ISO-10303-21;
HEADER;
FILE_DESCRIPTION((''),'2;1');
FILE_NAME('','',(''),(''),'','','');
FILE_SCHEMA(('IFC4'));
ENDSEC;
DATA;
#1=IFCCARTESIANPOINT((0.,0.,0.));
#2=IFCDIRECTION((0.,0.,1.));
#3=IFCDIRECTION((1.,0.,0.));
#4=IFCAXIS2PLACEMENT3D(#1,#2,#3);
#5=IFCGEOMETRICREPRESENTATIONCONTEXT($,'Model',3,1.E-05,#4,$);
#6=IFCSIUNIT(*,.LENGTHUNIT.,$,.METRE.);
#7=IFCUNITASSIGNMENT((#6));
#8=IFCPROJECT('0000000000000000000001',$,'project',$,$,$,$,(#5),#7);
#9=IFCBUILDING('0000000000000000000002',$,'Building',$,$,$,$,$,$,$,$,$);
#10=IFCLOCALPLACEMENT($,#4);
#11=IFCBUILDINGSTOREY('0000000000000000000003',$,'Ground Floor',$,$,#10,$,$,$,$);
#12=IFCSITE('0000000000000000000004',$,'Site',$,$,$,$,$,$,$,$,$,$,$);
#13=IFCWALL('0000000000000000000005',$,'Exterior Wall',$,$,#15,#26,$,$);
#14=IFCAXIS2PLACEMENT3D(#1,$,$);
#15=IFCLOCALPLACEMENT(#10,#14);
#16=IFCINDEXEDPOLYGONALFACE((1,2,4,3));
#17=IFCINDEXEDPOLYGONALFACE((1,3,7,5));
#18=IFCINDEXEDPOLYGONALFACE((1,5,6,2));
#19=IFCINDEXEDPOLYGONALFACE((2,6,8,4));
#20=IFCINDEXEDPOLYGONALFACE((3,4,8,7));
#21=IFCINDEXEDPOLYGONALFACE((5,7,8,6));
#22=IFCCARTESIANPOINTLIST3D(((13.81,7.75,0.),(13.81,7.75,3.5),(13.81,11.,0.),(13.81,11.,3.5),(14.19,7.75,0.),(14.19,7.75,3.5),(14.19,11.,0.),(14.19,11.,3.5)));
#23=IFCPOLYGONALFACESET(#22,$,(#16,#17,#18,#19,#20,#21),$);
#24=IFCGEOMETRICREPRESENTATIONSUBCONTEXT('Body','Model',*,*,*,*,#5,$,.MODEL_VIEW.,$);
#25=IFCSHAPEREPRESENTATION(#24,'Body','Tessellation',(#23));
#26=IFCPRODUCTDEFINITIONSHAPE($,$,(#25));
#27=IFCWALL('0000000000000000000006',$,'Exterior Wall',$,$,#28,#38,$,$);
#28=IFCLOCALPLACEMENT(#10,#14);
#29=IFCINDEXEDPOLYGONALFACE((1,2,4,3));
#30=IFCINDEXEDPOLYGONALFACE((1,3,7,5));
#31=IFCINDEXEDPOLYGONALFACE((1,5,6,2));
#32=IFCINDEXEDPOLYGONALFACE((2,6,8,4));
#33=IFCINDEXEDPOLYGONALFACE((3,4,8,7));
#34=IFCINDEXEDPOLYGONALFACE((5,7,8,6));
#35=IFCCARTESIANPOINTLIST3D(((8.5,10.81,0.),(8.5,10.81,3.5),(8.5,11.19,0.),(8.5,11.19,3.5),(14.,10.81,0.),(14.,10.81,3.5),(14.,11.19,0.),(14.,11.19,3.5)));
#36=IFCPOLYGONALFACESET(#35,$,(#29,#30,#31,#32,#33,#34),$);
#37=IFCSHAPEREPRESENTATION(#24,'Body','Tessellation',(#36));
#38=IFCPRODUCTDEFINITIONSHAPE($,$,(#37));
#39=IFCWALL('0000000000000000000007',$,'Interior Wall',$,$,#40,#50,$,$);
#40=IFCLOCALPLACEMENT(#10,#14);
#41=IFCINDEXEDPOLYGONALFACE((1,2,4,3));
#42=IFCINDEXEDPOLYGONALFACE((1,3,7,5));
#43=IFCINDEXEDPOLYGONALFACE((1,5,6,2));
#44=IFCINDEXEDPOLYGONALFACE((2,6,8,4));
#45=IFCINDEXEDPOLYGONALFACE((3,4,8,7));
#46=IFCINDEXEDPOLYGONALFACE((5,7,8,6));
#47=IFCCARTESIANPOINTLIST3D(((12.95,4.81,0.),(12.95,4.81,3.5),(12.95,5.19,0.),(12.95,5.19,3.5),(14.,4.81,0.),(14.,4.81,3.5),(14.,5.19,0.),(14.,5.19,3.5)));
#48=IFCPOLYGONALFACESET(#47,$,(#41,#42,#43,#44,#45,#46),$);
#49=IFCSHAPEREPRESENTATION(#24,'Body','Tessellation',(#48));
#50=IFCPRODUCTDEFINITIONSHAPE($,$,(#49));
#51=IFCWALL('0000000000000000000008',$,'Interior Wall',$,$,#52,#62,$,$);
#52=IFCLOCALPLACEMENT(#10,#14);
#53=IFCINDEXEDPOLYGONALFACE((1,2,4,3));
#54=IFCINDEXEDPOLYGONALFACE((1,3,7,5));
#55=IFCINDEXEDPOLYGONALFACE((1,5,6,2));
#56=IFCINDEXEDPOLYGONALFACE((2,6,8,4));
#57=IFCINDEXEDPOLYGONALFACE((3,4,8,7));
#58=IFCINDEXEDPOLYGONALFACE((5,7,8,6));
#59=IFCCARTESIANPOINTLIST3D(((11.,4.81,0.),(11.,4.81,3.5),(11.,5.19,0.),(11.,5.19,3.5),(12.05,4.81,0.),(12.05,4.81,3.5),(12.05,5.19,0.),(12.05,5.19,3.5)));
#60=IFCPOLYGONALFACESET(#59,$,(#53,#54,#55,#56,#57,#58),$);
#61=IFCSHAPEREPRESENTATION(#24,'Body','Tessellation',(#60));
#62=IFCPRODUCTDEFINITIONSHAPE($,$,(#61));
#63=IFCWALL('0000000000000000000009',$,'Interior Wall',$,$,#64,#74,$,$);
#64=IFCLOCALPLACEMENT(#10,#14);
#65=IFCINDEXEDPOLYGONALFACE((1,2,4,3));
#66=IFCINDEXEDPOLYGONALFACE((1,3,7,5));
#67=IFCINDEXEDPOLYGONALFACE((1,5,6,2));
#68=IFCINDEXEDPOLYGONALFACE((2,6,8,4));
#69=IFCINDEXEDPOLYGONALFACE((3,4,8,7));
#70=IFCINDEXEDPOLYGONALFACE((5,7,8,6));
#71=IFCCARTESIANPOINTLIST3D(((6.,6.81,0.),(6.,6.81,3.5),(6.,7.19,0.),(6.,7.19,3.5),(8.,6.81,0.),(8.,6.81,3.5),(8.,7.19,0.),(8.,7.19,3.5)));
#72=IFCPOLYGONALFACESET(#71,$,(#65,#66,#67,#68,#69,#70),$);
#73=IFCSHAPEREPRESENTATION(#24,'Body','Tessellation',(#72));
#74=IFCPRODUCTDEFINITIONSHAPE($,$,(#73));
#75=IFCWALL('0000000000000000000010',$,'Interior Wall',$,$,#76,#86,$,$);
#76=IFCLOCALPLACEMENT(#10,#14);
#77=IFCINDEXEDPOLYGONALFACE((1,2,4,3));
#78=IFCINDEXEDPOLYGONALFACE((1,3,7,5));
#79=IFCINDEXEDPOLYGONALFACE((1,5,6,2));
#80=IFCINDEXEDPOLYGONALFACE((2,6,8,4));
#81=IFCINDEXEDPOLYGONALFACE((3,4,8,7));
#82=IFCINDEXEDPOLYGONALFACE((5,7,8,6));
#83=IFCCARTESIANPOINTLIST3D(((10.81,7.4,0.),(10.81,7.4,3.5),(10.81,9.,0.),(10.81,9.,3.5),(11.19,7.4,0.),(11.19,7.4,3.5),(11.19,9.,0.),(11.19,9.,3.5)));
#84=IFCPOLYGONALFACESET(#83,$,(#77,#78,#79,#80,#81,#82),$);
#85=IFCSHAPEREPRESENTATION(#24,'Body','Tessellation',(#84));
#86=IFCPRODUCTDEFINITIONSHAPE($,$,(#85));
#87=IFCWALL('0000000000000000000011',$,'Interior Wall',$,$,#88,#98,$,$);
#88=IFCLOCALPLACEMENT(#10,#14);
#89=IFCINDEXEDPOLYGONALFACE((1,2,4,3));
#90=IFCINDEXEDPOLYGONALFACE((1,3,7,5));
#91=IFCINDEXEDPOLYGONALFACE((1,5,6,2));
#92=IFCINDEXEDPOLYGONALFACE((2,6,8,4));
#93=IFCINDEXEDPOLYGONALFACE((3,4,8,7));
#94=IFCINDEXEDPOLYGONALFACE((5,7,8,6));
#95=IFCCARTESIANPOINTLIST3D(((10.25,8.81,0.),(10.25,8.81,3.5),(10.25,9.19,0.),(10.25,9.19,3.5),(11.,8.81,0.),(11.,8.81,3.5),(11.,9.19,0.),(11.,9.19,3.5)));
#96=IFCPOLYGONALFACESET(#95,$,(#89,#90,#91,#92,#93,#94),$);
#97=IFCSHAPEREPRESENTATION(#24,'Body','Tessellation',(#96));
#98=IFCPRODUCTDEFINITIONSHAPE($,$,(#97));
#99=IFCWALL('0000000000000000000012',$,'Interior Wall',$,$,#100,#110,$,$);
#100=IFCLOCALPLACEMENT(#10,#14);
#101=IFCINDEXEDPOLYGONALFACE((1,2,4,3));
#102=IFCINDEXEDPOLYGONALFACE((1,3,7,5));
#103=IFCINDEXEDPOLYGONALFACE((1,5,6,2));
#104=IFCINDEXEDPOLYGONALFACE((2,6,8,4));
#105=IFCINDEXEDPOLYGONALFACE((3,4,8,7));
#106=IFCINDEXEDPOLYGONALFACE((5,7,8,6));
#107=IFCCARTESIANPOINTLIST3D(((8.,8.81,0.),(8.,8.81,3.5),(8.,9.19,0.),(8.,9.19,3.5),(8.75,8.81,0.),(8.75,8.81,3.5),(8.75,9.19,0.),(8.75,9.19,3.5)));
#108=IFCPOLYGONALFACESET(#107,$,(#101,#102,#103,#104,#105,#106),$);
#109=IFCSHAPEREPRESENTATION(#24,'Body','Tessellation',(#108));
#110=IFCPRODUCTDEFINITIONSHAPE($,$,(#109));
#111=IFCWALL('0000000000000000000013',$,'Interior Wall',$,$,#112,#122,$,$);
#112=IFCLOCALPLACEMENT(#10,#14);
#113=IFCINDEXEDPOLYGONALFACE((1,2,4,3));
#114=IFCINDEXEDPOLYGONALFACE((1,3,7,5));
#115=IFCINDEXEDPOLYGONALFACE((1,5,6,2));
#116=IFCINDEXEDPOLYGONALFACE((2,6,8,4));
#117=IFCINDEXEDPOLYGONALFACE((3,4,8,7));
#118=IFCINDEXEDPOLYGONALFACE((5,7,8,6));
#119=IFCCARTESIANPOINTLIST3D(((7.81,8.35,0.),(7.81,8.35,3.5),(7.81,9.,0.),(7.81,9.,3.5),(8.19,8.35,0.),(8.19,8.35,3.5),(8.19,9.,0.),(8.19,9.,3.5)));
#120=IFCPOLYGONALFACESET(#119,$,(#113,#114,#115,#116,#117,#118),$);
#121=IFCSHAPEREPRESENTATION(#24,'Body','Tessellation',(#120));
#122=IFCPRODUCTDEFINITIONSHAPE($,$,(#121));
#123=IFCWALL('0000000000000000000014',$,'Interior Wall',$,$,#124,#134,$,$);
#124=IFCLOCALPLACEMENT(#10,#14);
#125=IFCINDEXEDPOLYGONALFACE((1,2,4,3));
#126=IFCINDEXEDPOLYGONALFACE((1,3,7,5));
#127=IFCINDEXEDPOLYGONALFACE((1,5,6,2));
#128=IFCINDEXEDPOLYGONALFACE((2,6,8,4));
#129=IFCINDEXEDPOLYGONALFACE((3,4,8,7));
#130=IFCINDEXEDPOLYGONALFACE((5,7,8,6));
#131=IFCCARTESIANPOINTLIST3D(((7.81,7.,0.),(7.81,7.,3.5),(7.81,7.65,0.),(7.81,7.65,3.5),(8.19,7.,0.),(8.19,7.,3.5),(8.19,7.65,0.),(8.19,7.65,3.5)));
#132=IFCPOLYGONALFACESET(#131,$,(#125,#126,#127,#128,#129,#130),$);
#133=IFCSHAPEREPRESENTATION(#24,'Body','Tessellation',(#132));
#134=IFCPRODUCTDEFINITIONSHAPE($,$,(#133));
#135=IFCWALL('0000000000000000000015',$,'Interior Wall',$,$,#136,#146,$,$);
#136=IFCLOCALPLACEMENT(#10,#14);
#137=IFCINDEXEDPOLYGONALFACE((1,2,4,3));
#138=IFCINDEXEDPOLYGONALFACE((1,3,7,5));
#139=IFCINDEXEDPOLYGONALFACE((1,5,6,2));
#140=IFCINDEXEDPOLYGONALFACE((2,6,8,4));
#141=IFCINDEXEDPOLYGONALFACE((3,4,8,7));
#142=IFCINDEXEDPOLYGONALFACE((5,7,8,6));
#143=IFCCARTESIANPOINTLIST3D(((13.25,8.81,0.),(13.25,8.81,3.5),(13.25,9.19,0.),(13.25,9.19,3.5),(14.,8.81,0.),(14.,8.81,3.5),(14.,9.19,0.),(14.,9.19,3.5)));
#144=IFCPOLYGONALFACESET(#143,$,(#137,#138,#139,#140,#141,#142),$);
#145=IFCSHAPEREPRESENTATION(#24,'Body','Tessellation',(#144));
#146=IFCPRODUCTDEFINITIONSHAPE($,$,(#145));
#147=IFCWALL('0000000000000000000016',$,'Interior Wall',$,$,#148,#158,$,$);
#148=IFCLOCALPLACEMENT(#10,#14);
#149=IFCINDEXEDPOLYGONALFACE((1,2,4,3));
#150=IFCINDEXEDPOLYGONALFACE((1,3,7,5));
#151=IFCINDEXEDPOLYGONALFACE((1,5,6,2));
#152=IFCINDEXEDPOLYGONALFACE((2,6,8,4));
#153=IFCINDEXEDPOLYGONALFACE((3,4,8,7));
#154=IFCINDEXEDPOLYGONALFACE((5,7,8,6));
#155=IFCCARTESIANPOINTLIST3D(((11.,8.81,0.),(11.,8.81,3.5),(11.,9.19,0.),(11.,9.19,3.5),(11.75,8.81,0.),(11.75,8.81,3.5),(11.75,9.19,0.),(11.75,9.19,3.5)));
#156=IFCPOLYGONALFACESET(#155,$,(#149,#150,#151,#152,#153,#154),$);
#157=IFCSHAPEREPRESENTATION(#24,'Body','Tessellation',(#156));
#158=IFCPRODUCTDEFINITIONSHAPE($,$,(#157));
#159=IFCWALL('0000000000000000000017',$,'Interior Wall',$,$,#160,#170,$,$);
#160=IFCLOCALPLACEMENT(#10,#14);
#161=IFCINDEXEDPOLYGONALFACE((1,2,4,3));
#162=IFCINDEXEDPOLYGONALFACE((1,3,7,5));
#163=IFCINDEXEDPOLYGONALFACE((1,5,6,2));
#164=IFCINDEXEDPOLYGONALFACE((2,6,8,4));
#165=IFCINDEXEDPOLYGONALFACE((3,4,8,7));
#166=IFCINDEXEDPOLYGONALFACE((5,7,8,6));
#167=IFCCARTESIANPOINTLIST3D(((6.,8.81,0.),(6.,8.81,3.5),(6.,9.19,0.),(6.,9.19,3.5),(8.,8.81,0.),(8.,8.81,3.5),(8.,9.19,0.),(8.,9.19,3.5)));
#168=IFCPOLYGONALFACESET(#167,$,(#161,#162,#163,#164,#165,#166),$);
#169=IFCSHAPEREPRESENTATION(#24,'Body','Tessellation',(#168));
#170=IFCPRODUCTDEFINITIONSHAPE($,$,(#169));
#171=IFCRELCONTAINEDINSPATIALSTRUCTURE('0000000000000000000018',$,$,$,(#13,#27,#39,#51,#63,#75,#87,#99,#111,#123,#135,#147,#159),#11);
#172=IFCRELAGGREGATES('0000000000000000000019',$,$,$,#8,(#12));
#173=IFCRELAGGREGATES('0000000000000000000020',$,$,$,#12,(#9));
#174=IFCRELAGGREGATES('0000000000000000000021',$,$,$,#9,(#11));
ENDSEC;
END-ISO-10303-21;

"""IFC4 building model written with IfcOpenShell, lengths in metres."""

from ifc_helpers import new_model, si_unit, frame, origin_with_axes, place, context, subcontext, project, spatial, indexed_curve, outline, extrude, element, save


model = new_model("IFC4")

# Units and contexts
model_context = context("Model", 3, precision=1e-05, world=origin_with_axes())
body_context = subcontext(model_context, "Body", "Model", "MODEL_VIEW")
ifc_project = project(units=[si_unit("LENGTHUNIT", "METRE")], contexts=[model_context])

# Site, building, storey
site = spatial("IfcSite", under=ifc_project, Name="Site")
building = spatial("IfcBuilding", under=site, Name="Building")
storey_placement = place(None, origin_with_axes())
storey = spatial("IfcBuildingStorey", under=building, at=storey_placement, Name="Ground Floor")

# Walls
wall_1_placement = place(storey_placement, frame((14.0, 7.75, 0.0), z_axis=(0.0, 0.0, 1.0), x_axis=(0.0, 1.0, 0.0)))
element("IfcWall", 1, at=wall_1_placement, inside=storey, Name="Exterior Wall", context=body_context, shape_type="SweptSolid", body=[
    extrude(outline(indexed_curve([(0.0, 0.0), (0.0, 0.38), (3.25, 0.38), (3.25, 0.0), (0.0, 0.0)], self_intersect=False)), frame((0.0, -0.19, 0.0), z_axis=(0.0, 0.0, 1.0), x_axis=(1.0, 0.0, 0.0)), (0.0, 0.0, 1.0), 3.5),
])
wall_2_placement = place(storey_placement, frame((14.0, 11.0, 0.0), z_axis=(0.0, 0.0, 1.0), x_axis=(-1.0, 0.0, 0.0)))
element("IfcWall", 2, at=wall_2_placement, inside=storey, Name="Exterior Wall", context=body_context, shape_type="SweptSolid", body=[
    extrude(outline(indexed_curve([(0.0, 0.0), (0.0, 0.38), (5.5, 0.38), (5.5, 0.0), (0.0, 0.0)], self_intersect=False)), frame((0.0, -0.19, 0.0), z_axis=(0.0, 0.0, 1.0), x_axis=(1.0, 0.0, 0.0)), (0.0, 0.0, 1.0), 3.5),
])
for number, where, z_axis, x_axis, name in (
    (3, (14.0, 5.0, 0.0), (0.0, 0.0, 1.0), (-1.0, 0.0, 0.0), "Interior Wall"),
    (4, (12.05, 5.0, 0.0), (0.0, 0.0, 1.0), (-1.0, 0.0, 0.0), "Interior Wall"),
):
    element("IfcWall", number, at=place(storey_placement, frame(where, z_axis=z_axis, x_axis=x_axis)), inside=storey, Name=name, context=body_context, shape_type="SweptSolid", body=[
        extrude(outline(indexed_curve([(0.0, 0.0), (0.0, 0.38), (1.05, 0.38), (1.05, 0.0), (0.0, 0.0)], self_intersect=False)), frame((0.0, -0.19, 0.0), z_axis=(0.0, 0.0, 1.0), x_axis=(1.0, 0.0, 0.0)), (0.0, 0.0, 1.0), 3.5),
    ])
wall_3_placement = place(storey_placement, frame((8.0, 7.0, 0.0), z_axis=(0.0, 0.0, 1.0), x_axis=(-1.0, 0.0, 0.0)))
element("IfcWall", 5, at=wall_3_placement, inside=storey, Name="Interior Wall", context=body_context, shape_type="SweptSolid", body=[
    extrude(outline(indexed_curve([(0.0, 0.0), (0.0, 0.38), (2.0, 0.38), (2.0, 0.0), (0.0, 0.0)], self_intersect=False)), frame((0.0, -0.19, 0.0), z_axis=(0.0, 0.0, 1.0), x_axis=(1.0, 0.0, 0.0)), (0.0, 0.0, 1.0), 3.5),
])
wall_4_placement = place(storey_placement, frame((11.0, 7.4, 0.0), z_axis=(0.0, 0.0, 1.0), x_axis=(0.0, 1.0, 0.0)))
element("IfcWall", 6, at=wall_4_placement, inside=storey, Name="Interior Wall", context=body_context, shape_type="SweptSolid", body=[
    extrude(outline(indexed_curve([(0.0, 0.0), (0.0, 0.38), (1.6, 0.38), (1.6, 0.0), (0.0, 0.0)], self_intersect=False)), frame((0.0, -0.19, 0.0), z_axis=(0.0, 0.0, 1.0), x_axis=(1.0, 0.0, 0.0)), (0.0, 0.0, 1.0), 3.5),
])
for number, where, z_axis, x_axis, name in (
    (7, (11.0, 9.0, 0.0), (0.0, 0.0, 1.0), (-1.0, 0.0, 0.0), "Interior Wall"),
    (8, (8.75, 9.0, 0.0), (0.0, 0.0, 1.0), (-1.0, 0.0, 0.0), "Interior Wall"),
):
    element("IfcWall", number, at=place(storey_placement, frame(where, z_axis=z_axis, x_axis=x_axis)), inside=storey, Name=name, context=body_context, shape_type="SweptSolid", body=[
        extrude(outline(indexed_curve([(0.0, 0.0), (0.0, 0.38), (0.75, 0.38), (0.75, 0.0), (0.0, 0.0)], self_intersect=False)), frame((0.0, -0.19, 0.0), z_axis=(0.0, 0.0, 1.0), x_axis=(1.0, 0.0, 0.0)), (0.0, 0.0, 1.0), 3.5),
    ])
for number, where, z_axis, x_axis, name in (
    (9, (8.0, 9.0, 0.0), (0.0, 0.0, 1.0), (0.0, -1.0, 0.0), "Interior Wall"),
    (10, (8.0, 7.65, 0.0), (0.0, 0.0, 1.0), (0.0, -1.0, 0.0), "Interior Wall"),
):
    element("IfcWall", number, at=place(storey_placement, frame(where, z_axis=z_axis, x_axis=x_axis)), inside=storey, Name=name, context=body_context, shape_type="SweptSolid", body=[
        extrude(outline(indexed_curve([(0.0, 0.0), (0.0, 0.38), (0.65, 0.38), (0.65, 0.0), (0.0, 0.0)], self_intersect=False)), frame((0.0, -0.19, 0.0), z_axis=(0.0, 0.0, 1.0), x_axis=(1.0, 0.0, 0.0)), (0.0, 0.0, 1.0), 3.5),
    ])
for number, where, z_axis, x_axis, name in (
    (11, (14.0, 9.0, 0.0), (0.0, 0.0, 1.0), (-1.0, 0.0, 0.0), "Interior Wall"),
    (12, (11.75, 9.0, 0.0), (0.0, 0.0, 1.0), (-1.0, 0.0, 0.0), "Interior Wall"),
):
    element("IfcWall", number, at=place(storey_placement, frame(where, z_axis=z_axis, x_axis=x_axis)), inside=storey, Name=name, context=body_context, shape_type="SweptSolid", body=[
        extrude(outline(indexed_curve([(0.0, 0.0), (0.0, 0.38), (0.75, 0.38), (0.75, 0.0), (0.0, 0.0)], self_intersect=False)), frame((0.0, -0.19, 0.0), z_axis=(0.0, 0.0, 1.0), x_axis=(1.0, 0.0, 0.0)), (0.0, 0.0, 1.0), 3.5),
    ])
wall_5_placement = place(storey_placement, frame((8.0, 9.0, 0.0), z_axis=(0.0, 0.0, 1.0), x_axis=(-1.0, 0.0, 0.0)))
element("IfcWall", 13, at=wall_5_placement, inside=storey, Name="Interior Wall", context=body_context, shape_type="SweptSolid", body=[
    extrude(outline(indexed_curve([(0.0, 0.0), (0.0, 0.38), (2.0, 0.38), (2.0, 0.0), (0.0, 0.0)], self_intersect=False)), frame((0.0, -0.19, 0.0), z_axis=(0.0, 0.0, 1.0), x_axis=(1.0, 0.0, 0.0)), (0.0, 0.0, 1.0), 3.5),
])

save(model, "model.ifc")
